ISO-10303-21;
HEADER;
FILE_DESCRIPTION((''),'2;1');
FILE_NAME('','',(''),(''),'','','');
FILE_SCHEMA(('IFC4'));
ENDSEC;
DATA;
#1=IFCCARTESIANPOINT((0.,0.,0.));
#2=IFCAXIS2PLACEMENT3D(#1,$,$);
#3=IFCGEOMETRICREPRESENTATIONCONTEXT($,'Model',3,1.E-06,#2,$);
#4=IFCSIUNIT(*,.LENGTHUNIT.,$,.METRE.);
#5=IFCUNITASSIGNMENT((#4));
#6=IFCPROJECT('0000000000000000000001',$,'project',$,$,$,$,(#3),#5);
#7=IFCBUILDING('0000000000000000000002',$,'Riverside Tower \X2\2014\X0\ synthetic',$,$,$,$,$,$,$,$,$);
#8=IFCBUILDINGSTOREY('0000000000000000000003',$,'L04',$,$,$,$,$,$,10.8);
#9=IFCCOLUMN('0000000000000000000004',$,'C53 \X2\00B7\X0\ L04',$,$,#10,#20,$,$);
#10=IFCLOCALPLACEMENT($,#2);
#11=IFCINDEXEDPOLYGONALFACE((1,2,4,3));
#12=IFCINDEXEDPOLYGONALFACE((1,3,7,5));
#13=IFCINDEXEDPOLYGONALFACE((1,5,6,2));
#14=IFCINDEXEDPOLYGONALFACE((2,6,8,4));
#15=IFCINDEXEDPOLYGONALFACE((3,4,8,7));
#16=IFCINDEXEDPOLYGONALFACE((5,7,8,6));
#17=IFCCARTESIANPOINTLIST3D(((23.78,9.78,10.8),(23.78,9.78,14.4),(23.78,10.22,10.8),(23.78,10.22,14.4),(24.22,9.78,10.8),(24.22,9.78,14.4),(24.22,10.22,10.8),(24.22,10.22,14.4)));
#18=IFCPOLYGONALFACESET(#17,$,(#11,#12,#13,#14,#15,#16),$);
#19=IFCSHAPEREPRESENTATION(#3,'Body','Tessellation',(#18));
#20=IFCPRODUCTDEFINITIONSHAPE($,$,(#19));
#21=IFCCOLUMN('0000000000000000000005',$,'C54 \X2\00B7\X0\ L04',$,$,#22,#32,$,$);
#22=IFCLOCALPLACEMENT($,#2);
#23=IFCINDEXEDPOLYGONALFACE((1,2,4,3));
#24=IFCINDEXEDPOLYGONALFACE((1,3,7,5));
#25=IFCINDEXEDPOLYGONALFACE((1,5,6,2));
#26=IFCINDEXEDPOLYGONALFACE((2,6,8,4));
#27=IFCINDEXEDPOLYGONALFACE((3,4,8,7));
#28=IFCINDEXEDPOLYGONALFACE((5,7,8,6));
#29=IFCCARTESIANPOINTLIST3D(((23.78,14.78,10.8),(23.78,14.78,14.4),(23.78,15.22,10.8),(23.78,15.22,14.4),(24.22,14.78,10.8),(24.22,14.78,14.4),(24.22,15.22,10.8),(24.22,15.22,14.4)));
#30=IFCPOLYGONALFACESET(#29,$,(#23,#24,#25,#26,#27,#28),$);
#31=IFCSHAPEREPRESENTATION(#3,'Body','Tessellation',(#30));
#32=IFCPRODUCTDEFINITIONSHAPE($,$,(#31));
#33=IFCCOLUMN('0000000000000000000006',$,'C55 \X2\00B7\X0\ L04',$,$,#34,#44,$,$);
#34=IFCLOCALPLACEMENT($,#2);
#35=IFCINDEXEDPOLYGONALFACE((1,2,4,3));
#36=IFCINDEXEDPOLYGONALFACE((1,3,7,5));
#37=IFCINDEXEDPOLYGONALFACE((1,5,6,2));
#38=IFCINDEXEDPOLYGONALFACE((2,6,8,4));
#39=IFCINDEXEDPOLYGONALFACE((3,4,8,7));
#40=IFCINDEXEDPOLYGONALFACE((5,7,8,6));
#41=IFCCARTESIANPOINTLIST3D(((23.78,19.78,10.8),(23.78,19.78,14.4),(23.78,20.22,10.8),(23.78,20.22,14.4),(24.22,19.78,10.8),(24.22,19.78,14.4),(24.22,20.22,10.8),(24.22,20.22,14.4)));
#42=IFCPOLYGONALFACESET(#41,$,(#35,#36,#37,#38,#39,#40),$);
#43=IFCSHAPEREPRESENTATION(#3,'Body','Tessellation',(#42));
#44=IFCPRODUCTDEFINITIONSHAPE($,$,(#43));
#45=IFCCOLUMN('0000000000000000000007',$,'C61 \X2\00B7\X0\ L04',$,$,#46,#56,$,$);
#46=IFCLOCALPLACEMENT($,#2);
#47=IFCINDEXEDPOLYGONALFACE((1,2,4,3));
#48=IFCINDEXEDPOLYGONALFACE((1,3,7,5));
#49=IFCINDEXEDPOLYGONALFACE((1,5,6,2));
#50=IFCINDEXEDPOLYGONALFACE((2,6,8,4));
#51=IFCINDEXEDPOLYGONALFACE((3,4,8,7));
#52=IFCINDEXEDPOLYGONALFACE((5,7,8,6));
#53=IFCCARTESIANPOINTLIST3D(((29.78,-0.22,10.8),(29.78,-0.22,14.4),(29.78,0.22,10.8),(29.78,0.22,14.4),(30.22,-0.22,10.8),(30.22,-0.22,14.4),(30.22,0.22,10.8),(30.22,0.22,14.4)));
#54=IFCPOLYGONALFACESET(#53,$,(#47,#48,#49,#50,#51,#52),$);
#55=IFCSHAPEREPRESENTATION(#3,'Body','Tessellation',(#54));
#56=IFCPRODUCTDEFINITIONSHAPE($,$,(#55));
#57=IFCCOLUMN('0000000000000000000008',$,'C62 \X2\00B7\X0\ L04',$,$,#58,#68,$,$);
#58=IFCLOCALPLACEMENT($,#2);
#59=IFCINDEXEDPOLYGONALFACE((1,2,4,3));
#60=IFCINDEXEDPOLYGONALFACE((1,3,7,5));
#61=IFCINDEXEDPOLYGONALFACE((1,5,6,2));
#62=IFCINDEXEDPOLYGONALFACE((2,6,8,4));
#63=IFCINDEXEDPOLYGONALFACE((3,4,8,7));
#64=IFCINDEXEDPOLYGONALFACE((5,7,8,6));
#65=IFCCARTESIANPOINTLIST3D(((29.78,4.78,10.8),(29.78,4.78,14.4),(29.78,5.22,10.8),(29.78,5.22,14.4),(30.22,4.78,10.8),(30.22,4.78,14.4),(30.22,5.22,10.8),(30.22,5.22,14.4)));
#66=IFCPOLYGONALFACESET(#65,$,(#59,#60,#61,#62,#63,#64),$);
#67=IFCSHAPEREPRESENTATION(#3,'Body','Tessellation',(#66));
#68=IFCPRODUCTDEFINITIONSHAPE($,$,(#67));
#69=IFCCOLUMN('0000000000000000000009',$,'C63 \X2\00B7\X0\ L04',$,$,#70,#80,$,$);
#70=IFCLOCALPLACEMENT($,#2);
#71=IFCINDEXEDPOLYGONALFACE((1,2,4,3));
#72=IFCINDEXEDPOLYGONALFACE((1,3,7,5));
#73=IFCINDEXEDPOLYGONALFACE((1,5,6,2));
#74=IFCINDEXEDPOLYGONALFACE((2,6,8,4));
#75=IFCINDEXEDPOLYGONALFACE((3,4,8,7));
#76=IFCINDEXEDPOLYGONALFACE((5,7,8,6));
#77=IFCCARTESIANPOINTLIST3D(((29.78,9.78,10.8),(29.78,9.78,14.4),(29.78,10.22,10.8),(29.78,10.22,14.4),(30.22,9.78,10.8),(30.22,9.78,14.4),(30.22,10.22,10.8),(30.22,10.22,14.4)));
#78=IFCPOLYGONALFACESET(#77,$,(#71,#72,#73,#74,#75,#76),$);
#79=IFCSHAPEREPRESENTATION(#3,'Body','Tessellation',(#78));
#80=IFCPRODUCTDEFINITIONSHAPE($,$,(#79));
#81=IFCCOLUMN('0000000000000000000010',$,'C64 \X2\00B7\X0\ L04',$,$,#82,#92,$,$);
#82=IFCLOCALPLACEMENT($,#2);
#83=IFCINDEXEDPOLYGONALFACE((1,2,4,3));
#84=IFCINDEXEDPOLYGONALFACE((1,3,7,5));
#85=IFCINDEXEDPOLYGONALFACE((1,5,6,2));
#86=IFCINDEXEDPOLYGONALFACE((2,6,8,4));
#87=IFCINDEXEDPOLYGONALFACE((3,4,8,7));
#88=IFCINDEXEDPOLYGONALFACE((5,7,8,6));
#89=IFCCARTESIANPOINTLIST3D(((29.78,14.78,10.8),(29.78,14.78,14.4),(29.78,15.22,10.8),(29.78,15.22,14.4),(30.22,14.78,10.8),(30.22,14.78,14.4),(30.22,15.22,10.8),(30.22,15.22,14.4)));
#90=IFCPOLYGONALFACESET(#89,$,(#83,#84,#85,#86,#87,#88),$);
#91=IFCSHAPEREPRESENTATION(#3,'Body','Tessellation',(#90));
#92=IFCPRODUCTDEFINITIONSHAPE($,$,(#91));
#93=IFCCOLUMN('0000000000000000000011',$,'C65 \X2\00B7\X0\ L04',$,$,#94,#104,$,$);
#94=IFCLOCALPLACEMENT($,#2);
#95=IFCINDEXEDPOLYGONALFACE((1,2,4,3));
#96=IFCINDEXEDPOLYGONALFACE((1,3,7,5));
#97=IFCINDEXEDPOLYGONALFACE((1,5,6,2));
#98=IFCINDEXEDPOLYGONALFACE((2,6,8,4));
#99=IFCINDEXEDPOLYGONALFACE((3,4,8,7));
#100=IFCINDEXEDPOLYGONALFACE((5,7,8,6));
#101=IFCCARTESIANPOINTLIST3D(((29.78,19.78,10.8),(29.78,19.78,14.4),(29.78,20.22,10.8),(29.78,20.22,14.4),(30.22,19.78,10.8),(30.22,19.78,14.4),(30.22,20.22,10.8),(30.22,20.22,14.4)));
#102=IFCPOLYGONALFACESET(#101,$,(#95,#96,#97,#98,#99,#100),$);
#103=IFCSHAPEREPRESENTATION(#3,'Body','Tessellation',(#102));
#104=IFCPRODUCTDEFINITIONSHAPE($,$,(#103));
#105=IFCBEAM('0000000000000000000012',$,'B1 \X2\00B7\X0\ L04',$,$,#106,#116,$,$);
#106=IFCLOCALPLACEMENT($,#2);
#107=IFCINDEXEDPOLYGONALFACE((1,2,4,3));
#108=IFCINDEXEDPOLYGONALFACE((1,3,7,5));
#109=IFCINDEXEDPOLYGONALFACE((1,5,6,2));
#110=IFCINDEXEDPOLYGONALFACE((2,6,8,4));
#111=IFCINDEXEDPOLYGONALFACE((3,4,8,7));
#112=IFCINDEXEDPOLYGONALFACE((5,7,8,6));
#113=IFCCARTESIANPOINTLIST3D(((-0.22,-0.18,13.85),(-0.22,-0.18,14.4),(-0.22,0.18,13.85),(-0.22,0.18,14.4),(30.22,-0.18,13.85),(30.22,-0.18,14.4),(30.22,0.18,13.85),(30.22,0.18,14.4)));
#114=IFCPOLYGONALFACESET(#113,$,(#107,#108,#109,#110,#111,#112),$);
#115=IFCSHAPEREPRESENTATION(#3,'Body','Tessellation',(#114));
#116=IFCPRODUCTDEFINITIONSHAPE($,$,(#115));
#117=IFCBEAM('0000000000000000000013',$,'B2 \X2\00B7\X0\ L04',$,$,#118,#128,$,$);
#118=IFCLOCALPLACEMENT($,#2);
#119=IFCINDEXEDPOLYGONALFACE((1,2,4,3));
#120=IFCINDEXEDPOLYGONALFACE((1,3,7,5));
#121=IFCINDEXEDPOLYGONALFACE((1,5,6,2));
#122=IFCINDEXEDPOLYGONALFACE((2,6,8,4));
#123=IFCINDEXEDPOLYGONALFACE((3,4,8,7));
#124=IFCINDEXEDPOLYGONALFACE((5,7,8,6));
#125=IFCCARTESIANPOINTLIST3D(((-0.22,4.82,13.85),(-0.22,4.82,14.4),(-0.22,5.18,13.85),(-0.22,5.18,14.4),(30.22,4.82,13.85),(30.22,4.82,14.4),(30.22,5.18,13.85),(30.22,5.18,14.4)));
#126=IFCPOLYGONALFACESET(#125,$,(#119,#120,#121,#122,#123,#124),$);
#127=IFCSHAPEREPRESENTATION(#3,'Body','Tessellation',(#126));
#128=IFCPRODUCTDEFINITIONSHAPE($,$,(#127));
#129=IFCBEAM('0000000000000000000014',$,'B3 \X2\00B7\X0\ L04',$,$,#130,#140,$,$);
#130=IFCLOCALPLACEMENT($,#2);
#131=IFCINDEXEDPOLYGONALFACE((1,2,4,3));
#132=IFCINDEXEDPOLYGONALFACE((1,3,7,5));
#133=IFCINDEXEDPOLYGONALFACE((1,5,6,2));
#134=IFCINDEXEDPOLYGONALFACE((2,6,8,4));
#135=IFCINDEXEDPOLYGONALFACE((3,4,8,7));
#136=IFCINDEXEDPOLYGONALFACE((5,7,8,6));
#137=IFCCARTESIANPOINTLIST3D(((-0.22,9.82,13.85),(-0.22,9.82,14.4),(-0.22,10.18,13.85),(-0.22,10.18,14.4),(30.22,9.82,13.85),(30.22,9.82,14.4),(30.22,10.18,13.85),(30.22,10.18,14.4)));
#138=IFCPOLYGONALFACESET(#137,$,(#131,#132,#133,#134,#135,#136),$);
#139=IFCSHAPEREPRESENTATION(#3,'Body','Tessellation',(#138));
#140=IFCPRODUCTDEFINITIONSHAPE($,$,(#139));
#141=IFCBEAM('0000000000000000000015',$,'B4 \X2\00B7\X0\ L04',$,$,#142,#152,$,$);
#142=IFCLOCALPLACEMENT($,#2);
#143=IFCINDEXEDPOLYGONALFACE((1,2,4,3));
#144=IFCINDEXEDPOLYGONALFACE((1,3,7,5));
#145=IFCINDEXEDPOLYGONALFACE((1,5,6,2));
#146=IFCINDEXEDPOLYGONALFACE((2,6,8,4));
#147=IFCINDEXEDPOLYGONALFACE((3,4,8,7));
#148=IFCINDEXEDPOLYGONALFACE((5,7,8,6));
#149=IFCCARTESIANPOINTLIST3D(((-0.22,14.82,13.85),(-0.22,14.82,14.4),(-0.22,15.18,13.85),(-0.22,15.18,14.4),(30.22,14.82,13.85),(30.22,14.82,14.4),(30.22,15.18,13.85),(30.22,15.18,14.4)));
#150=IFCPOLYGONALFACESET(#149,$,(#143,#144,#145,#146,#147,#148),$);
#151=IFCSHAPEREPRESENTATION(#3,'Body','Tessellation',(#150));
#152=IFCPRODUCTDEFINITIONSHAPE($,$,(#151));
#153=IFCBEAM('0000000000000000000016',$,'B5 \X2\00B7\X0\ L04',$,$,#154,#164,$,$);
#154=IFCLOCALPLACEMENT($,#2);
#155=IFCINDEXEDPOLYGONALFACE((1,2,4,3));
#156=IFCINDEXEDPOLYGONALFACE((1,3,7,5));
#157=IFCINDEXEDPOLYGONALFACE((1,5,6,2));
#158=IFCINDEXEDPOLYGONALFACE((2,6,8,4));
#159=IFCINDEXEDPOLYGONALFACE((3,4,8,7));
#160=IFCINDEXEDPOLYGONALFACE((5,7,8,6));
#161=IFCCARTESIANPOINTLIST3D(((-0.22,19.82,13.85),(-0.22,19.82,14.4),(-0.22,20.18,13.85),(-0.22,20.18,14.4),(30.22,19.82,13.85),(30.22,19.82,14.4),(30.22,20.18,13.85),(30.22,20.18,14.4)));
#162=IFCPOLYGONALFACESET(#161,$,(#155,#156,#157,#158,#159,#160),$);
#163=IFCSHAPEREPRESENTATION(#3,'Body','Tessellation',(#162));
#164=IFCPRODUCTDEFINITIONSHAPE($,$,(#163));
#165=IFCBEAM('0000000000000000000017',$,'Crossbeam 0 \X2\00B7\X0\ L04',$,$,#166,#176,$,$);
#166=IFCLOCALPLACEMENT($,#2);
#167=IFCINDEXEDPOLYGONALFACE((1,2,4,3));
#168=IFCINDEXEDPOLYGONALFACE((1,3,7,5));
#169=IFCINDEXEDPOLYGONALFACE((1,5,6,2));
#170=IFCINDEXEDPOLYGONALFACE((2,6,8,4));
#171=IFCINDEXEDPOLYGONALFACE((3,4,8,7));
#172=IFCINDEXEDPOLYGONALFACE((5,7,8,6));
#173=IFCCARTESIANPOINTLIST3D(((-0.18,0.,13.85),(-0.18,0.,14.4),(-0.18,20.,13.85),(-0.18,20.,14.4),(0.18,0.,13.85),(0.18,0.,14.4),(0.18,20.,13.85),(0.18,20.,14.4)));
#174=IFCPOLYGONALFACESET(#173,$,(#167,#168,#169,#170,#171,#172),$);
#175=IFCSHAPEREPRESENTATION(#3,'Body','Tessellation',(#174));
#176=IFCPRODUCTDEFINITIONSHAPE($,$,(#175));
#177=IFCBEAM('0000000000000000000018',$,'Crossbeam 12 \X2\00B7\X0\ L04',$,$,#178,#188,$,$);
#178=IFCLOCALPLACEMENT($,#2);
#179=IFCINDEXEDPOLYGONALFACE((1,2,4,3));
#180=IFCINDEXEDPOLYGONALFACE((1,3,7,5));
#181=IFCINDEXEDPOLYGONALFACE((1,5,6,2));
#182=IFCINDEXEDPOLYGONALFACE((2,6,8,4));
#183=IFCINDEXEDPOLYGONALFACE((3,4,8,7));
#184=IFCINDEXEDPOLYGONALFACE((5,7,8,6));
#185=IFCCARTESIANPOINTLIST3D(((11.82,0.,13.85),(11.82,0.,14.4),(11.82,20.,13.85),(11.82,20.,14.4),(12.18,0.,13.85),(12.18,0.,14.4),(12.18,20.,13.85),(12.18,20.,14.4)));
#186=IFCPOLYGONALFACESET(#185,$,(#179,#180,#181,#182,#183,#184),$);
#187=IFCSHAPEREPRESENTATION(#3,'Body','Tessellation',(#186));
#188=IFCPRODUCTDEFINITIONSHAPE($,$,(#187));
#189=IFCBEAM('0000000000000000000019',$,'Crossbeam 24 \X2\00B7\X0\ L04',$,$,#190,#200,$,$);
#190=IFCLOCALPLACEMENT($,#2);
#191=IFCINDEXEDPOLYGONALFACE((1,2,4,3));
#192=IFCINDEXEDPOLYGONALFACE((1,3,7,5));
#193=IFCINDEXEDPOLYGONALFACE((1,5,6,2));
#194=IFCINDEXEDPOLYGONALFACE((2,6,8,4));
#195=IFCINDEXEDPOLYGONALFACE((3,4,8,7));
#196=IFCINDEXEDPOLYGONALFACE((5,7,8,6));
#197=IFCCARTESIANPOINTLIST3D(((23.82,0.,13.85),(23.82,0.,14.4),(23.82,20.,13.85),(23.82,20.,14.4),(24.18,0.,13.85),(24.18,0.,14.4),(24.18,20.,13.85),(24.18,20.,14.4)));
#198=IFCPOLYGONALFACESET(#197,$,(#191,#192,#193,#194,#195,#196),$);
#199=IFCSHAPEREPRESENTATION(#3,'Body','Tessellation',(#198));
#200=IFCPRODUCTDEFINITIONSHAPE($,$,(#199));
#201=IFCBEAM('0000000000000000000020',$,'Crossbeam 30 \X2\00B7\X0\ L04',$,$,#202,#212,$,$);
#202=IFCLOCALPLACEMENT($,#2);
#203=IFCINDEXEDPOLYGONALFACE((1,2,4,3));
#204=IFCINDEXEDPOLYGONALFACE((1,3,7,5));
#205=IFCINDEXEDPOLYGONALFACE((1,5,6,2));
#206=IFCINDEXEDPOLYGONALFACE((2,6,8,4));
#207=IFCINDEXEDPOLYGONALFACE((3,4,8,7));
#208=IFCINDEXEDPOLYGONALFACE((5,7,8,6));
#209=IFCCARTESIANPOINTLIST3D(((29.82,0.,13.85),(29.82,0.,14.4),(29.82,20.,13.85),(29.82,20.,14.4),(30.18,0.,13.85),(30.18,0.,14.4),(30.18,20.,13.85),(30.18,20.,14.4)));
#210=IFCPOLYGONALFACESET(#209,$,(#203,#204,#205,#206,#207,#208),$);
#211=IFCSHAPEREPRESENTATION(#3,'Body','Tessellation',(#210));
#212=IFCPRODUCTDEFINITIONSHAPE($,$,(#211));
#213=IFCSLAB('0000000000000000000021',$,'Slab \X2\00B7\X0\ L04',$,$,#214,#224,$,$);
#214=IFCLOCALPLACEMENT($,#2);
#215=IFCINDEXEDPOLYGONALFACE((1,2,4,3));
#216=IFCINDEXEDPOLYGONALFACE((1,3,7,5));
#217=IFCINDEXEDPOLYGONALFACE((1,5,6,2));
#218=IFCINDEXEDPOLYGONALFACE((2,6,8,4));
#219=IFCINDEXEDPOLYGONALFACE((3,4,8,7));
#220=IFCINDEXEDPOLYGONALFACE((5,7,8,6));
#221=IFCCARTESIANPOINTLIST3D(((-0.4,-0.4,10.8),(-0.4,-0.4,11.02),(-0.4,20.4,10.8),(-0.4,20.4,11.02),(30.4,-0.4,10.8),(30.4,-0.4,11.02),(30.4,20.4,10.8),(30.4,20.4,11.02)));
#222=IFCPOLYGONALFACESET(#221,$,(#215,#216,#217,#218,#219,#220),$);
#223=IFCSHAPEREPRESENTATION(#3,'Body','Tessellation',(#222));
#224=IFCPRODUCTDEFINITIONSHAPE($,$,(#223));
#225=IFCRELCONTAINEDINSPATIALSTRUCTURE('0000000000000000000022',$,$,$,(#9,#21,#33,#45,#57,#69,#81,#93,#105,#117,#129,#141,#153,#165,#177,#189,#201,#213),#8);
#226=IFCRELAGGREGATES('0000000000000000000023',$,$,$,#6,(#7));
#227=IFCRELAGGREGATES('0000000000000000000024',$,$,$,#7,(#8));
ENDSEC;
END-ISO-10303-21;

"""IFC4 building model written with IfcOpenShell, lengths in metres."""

from ifc_helpers import new_model, si_unit, frame, origin, place, context, project, spatial, rectangle, extrude, element, save


model = new_model("IFC4")

# Units and contexts
model_context = context("Model", 3, precision=1e-06, world=origin())
ifc_project = project(units=[si_unit("LENGTHUNIT", "METRE")], contexts=[model_context])

# Building, storey
building = spatial("IfcBuilding", under=ifc_project, Name="Riverside Tower — synthetic")
storey = spatial("IfcBuildingStorey", under=building, Name="L04", Elevation=10.8)

# Columns
for number, where, name in (
    (1, (24.0, 10.0, 10.8), "C53 · L04"),
    (2, (24.0, 15.0, 10.8), "C54 · L04"),
    (3, (24.0, 20.0, 10.8), "C55 · L04"),
    (4, (30.0, 0.0, 10.8), "C61 · L04"),
    (5, (30.0, 5.0, 10.8), "C62 · L04"),
    (6, (30.0, 10.0, 10.8), "C63 · L04"),
    (7, (30.0, 15.0, 10.8), "C64 · L04"),
    (8, (30.0, 20.0, 10.8), "C65 · L04"),
):
    element("IfcColumn", number, at=place(None, frame(where)), inside=storey, Name=name, context=model_context, shape_type="SweptSolid", body=[
        extrude(rectangle(XDim=0.44, YDim=0.44), origin(), (0.0, 0.0, 1.0), 3.6),
    ])

# Beams
for number, where, name in (
    (9, (15.0, 0.0, 13.85), "B1 · L04"),
    (10, (15.0, 5.0, 13.85), "B2 · L04"),
    (11, (15.0, 10.0, 13.85), "B3 · L04"),
    (12, (15.0, 15.0, 13.85), "B4 · L04"),
    (13, (15.0, 20.0, 13.85), "B5 · L04"),
):
    element("IfcBeam", number, at=place(None, frame(where)), inside=storey, Name=name, context=model_context, shape_type="SweptSolid", body=[
        extrude(rectangle(XDim=30.44, YDim=0.36), origin(), (0.0, 0.0, 1.0), 0.55),
    ])
for number, where, name in (
    (14, (0.0, 10.0, 13.85), "Crossbeam 0 · L04"),
    (15, (12.0, 10.0, 13.85), "Crossbeam 12 · L04"),
    (16, (24.0, 10.0, 13.85), "Crossbeam 24 · L04"),
    (17, (30.0, 10.0, 13.85), "Crossbeam 30 · L04"),
):
    element("IfcBeam", number, at=place(None, frame(where)), inside=storey, Name=name, context=model_context, shape_type="SweptSolid", body=[
        extrude(rectangle(XDim=0.36, YDim=20.0), origin(), (0.0, 0.0, 1.0), 0.55),
    ])

# Slab
slab_placement = place(None, frame((15.0, 10.0, 10.8)))
element("IfcSlab", 18, at=slab_placement, inside=storey, Name="Slab · L04", context=model_context, shape_type="SweptSolid", body=[
    extrude(rectangle(XDim=30.8, YDim=20.8), origin(), (0.0, 0.0, 1.0), 0.22),
])

save(model, "model.ifc")
